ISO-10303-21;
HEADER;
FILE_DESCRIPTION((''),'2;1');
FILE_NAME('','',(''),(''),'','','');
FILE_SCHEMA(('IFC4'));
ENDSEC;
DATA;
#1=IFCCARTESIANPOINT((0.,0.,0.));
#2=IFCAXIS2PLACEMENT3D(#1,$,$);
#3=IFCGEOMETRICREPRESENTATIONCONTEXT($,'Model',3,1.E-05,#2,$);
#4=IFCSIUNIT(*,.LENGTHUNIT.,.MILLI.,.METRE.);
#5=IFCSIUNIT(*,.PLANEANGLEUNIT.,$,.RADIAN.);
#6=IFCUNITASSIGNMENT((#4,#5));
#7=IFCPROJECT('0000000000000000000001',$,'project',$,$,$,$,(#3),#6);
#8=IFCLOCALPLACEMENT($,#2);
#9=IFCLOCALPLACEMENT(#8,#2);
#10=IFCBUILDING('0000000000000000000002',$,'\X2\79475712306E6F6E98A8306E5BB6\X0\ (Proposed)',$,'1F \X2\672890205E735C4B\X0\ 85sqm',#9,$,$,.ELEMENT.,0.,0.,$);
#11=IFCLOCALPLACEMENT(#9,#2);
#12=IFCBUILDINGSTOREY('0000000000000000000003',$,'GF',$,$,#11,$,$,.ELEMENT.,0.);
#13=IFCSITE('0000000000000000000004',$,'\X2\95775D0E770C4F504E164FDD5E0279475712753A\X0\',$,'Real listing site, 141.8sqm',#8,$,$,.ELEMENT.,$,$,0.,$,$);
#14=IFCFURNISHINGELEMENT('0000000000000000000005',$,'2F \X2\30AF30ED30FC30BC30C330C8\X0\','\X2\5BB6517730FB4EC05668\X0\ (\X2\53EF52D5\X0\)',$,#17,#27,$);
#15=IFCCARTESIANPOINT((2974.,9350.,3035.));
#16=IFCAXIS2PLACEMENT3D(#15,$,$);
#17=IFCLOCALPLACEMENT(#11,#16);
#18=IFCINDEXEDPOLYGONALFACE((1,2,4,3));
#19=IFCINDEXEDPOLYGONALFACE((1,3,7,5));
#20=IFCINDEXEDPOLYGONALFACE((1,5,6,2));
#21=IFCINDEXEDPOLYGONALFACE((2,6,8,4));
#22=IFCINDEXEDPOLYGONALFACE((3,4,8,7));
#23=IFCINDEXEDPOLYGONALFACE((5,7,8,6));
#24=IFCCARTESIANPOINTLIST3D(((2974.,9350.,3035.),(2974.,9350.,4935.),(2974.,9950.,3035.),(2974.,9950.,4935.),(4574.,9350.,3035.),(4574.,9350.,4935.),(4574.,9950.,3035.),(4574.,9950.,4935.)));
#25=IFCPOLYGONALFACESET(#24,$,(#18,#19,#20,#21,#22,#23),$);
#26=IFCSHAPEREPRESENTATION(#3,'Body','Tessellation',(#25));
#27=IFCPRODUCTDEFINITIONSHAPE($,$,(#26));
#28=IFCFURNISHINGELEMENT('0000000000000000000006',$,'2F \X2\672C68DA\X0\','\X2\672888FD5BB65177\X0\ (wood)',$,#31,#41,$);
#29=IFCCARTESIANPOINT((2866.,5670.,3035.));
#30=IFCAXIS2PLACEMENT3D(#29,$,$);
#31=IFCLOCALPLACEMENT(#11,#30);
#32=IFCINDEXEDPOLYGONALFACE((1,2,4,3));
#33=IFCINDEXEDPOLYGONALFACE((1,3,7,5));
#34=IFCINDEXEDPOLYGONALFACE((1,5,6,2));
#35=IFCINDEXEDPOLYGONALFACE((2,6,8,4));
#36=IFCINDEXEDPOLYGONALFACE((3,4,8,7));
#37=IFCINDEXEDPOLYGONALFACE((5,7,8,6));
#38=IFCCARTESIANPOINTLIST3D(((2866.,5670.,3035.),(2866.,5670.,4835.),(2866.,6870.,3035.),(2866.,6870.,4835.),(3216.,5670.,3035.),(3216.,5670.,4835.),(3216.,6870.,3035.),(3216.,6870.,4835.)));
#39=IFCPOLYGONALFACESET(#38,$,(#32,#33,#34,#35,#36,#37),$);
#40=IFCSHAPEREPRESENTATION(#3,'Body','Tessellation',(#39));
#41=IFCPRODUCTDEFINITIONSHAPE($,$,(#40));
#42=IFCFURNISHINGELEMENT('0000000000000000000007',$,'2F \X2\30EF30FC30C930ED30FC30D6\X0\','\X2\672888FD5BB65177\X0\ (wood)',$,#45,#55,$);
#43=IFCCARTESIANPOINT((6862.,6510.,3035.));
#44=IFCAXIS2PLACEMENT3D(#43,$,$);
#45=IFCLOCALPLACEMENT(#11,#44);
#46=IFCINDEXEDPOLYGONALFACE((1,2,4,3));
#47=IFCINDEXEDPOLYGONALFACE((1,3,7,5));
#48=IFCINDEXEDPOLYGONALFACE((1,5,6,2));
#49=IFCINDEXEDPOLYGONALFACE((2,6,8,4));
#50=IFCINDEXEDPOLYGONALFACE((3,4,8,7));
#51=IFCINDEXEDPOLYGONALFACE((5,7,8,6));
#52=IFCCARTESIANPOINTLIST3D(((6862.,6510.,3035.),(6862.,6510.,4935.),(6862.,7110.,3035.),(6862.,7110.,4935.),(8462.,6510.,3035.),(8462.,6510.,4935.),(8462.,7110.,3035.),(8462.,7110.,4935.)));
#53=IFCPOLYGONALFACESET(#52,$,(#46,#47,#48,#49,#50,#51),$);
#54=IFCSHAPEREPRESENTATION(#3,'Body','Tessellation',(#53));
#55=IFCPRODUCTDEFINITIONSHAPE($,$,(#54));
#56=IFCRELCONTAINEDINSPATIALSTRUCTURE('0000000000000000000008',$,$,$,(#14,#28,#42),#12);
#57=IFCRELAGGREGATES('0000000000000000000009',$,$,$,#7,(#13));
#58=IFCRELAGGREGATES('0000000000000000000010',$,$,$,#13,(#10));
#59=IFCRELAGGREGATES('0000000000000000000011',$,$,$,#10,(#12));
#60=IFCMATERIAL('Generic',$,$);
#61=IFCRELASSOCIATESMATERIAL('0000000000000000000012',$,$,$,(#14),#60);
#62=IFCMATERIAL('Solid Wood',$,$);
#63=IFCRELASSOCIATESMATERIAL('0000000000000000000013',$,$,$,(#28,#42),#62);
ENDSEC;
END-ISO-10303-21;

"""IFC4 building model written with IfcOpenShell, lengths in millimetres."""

from ifc_helpers import new_model, si_unit, frame, frame_2d, origin, place, context, project, spatial, rectangle, extrude, material, element, save


model = new_model("IFC4")

# Units and contexts
model_context = context("Model", 3, precision=1e-05, world=origin())
ifc_project = project(units=[si_unit("LENGTHUNIT", "METRE", prefix="MILLI"), si_unit("PLANEANGLEUNIT", "RADIAN")], contexts=[model_context])

# Site, building, storey
site_placement = place(None, origin())
site = spatial("IfcSite", under=ifc_project, at=site_placement, Name="長崎県佐世保市祇園町", ObjectType="Real listing site, 141.8sqm", CompositionType="ELEMENT", RefElevation=0.0)
building_placement = place(site_placement, origin())
building = spatial("IfcBuilding", under=site, at=building_placement, Name="祇園の潮風の家 (Proposed)", ObjectType="1F 木造平屋 85sqm", CompositionType="ELEMENT", ElevationOfRefHeight=0.0, ElevationOfTerrain=0.0)
storey_placement = place(building_placement, origin())
storey = spatial("IfcBuildingStorey", under=building, at=storey_placement, Name="GF", CompositionType="ELEMENT", Elevation=0.0)

# Shared definitions
ifc_material_1 = material(Name="Solid Wood")

# Shared definitions
ifc_material_2 = material(Name="Generic")

# Furnishing elements
furnishing_1_placement = place(storey_placement, frame((2974.0, 9350.0, 3035.0)))
element("IfcFurnishingElement", 1, at=furnishing_1_placement, inside=storey, material=ifc_material_2, Name="2F クローゼット", Description="家具・什器 (可動)", context=model_context, shape_type="SweptSolid", body=[
    extrude(rectangle(XDim=1600.0, YDim=600.0, at=frame_2d((800.0, 300.0))), frame((2974.0, 9350.0, 3035.0)), (0.0, 0.0, 1.0), 1900.0),
])
furnishing_2_placement = place(storey_placement, frame((2866.0, 5670.0, 3035.0)))
element("IfcFurnishingElement", 2, at=furnishing_2_placement, inside=storey, material=ifc_material_1, Name="2F 本棚", Description="木製家具 (wood)", context=model_context, shape_type="SweptSolid", body=[
    extrude(rectangle(XDim=350.0, YDim=1200.0, at=frame_2d((175.0, 600.0))), frame((2866.0, 5670.0, 3035.0)), (0.0, 0.0, 1.0), 1800.0),
])
furnishing_3_placement = place(storey_placement, frame((6862.0, 6510.0, 3035.0)))
element("IfcFurnishingElement", 3, at=furnishing_3_placement, inside=storey, material=ifc_material_1, Name="2F ワードローブ", Description="木製家具 (wood)", context=model_context, shape_type="SweptSolid", body=[
    extrude(rectangle(XDim=1600.0, YDim=600.0, at=frame_2d((800.0, 300.0))), frame((6862.0, 6510.0, 3035.0)), (0.0, 0.0, 1.0), 1900.0),
])

save(model, "model.ifc")
